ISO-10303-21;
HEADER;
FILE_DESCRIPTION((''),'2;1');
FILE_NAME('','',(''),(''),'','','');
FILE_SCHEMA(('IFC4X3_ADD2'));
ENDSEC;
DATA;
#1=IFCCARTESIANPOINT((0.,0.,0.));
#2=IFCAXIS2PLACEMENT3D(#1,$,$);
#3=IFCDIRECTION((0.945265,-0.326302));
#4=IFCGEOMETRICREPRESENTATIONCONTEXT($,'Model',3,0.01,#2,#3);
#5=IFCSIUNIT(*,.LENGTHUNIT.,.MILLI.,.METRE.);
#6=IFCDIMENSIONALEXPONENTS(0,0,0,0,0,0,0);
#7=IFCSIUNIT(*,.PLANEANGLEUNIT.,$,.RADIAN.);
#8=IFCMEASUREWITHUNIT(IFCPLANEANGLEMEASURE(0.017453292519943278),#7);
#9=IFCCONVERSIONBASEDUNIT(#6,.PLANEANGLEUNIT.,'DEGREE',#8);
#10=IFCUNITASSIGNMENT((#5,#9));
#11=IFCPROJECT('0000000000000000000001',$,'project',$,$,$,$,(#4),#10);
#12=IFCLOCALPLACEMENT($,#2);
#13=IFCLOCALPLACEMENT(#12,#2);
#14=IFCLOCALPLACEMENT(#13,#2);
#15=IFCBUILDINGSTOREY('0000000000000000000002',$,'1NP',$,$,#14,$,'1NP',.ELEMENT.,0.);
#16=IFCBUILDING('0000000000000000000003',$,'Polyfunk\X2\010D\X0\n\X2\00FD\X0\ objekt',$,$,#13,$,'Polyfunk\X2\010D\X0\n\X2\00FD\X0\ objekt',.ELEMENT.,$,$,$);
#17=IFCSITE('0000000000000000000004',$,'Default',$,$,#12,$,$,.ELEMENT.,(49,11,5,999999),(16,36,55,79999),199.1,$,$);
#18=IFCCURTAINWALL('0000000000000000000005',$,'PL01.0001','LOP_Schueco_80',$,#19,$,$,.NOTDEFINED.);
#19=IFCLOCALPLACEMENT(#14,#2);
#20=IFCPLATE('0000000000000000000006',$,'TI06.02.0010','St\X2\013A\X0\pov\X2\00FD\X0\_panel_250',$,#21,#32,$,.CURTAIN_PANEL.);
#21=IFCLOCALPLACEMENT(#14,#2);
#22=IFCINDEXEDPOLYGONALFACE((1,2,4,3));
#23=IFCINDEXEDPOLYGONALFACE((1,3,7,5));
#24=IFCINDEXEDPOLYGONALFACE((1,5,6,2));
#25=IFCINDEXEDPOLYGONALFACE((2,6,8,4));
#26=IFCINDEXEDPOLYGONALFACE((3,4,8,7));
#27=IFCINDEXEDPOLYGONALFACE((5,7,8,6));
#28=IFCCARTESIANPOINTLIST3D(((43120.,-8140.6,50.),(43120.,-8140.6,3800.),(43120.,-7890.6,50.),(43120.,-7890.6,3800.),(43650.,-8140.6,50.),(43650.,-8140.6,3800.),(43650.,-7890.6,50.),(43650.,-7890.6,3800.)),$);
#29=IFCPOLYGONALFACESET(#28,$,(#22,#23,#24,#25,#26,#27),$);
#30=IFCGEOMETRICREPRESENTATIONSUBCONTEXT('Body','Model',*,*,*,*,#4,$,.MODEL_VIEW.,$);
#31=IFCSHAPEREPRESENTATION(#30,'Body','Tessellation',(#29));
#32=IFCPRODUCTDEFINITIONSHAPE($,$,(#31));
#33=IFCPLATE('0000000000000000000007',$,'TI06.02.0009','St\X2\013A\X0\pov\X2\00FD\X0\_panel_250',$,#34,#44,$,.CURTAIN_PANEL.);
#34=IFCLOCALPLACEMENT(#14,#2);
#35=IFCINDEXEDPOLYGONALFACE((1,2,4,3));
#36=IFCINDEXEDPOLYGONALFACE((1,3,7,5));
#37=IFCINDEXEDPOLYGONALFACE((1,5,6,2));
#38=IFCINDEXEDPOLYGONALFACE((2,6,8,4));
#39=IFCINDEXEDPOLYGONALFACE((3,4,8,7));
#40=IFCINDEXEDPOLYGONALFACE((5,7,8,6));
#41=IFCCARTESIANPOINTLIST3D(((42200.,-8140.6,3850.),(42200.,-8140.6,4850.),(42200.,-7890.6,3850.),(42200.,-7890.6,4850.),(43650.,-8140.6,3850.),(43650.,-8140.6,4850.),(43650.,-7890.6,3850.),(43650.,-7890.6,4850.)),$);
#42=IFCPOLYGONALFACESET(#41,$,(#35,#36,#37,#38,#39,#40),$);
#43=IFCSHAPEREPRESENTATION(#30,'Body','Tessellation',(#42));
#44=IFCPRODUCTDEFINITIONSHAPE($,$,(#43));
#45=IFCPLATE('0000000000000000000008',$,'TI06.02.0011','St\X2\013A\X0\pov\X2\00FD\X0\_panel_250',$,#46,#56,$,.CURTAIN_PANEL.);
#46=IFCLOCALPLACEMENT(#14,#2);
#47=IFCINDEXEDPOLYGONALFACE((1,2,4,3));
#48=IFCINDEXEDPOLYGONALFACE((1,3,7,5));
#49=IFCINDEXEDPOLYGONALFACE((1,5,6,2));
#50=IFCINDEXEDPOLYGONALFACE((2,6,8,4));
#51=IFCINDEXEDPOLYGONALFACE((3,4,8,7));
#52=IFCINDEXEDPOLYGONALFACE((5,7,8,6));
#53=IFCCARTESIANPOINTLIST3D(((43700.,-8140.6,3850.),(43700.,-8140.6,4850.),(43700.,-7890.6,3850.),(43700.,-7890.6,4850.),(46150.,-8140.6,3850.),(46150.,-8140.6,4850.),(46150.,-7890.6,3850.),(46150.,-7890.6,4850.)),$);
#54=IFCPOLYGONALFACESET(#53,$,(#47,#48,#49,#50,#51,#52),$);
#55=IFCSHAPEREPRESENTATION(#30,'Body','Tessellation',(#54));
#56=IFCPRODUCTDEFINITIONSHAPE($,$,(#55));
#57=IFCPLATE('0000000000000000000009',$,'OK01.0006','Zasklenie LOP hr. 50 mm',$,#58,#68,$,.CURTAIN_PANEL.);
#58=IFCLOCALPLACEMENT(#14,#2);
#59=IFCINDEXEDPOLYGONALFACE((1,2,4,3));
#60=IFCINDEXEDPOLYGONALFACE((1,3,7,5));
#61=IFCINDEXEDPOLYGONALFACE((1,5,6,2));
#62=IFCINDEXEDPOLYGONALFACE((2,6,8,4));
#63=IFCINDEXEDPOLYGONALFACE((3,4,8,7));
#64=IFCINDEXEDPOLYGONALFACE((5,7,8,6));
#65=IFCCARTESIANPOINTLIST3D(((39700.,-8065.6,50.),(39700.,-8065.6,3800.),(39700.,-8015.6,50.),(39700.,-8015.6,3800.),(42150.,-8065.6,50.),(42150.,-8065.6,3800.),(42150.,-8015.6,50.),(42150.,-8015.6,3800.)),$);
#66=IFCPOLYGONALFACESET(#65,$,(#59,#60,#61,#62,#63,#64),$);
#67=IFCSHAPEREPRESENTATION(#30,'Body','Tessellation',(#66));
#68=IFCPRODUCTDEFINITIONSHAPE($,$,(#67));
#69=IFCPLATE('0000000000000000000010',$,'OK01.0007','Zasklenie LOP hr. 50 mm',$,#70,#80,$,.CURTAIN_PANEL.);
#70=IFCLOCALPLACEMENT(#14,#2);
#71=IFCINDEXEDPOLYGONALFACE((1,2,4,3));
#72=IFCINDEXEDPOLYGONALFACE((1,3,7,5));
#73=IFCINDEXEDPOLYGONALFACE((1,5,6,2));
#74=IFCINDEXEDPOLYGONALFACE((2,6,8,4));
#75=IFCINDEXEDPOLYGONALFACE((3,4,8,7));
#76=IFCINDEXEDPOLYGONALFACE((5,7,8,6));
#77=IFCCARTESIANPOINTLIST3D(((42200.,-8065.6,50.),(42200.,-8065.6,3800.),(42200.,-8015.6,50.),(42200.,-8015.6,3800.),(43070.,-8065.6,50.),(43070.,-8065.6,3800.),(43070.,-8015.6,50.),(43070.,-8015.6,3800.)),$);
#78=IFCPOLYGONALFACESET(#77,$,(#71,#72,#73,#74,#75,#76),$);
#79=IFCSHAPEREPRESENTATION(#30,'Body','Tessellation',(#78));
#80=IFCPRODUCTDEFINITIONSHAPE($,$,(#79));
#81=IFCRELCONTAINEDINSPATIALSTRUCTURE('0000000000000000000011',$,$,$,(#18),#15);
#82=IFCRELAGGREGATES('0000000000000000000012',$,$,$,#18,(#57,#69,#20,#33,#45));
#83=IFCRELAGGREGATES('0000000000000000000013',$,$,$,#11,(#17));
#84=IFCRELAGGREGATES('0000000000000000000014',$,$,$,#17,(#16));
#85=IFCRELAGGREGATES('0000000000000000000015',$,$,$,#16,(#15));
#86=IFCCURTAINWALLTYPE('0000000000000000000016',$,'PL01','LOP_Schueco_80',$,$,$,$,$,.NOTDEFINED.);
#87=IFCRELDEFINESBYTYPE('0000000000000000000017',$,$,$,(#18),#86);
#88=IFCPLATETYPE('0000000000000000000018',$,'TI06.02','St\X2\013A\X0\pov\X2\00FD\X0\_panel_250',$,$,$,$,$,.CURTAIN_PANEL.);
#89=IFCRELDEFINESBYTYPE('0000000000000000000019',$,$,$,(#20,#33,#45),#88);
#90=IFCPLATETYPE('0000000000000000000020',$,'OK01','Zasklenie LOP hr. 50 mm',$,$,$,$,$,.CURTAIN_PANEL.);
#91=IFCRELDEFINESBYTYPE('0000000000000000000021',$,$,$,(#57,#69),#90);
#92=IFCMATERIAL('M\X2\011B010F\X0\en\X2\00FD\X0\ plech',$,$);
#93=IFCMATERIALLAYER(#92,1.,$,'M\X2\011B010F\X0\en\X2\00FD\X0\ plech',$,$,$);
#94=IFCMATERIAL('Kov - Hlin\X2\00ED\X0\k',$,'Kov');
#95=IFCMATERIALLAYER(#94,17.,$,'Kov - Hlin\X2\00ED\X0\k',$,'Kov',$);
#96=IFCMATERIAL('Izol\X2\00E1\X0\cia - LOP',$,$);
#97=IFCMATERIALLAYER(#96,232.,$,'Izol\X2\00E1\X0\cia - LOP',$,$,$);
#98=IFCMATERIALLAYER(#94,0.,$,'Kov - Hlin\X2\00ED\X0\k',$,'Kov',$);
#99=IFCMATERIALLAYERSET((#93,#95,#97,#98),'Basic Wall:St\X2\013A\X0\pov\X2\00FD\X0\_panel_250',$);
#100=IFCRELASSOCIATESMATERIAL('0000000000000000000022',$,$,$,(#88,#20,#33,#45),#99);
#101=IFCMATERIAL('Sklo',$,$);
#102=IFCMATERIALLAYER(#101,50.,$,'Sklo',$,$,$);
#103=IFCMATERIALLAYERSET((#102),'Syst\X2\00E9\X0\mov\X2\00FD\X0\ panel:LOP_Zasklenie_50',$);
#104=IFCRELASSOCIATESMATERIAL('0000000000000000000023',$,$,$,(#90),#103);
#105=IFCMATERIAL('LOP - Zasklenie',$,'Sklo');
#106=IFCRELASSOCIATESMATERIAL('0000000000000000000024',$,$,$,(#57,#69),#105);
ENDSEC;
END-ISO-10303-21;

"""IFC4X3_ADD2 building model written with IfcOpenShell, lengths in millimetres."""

from ifc_helpers import new_model, entity, si_unit, converted_unit, direction, frame, frame_2d, origin, place, context, subcontext, project, spatial, rectangle, extrude, source, transform, mapped, material, layer, layer_set, layer_usage, type_object, type_shapes, element, aggregate, save


model = new_model("IFC4X3_ADD2")

# Units and contexts
model_context = context("Model", 3, precision=0.01, world=origin(), true_north=direction((0.945265, -0.326302)))
body_context = subcontext(model_context, "Body", "Model", "MODEL_VIEW")
ifc_project = project(units=[si_unit("LENGTHUNIT", "METRE", prefix="MILLI"), converted_unit("PLANEANGLEUNIT", "DEGREE", entity("IfcPlaneAngleMeasure", 0.017453292519943278), si_unit("PLANEANGLEUNIT", "RADIAN"), dimensions=[0, 0, 0, 0, 0, 0, 0])], contexts=[model_context])

# Site, building, storey
site_placement = place(None, origin())
site = spatial("IfcSite", under=ifc_project, at=site_placement, Name="Default", CompositionType="ELEMENT", RefLatitude=(49, 11, 5, 999999), RefLongitude=(16, 36, 55, 79999), RefElevation=199.1)
building_placement = place(site_placement, origin())
building = spatial("IfcBuilding", under=site, at=building_placement, Name="Polyfunkčný objekt", LongName="Polyfunkčný objekt", CompositionType="ELEMENT")
storey_placement = place(building_placement, origin())
storey = spatial("IfcBuildingStorey", under=building, at=storey_placement, Name="1NP", LongName="1NP", CompositionType="ELEMENT", Elevation=0.0)

# Curtain wall, plates
curtain_wall_type = type_object("IfcCurtainWallType", Name="PL01", Description="LOP_Schueco_80", PredefinedType="NOTDEFINED")
curtain_wall_placement = place(storey_placement, origin())
curtain_wall = element("IfcCurtainWall", 1, at=curtain_wall_placement, inside=storey, type_object=curtain_wall_type, Name="PL01.0001", Description="LOP_Schueco_80", PredefinedType="NOTDEFINED")
ifc_material_1 = material(Name="Měďený plech")
ifc_layer_1 = layer(ifc_material_1, 1.0, Name="Měďený plech")
ifc_material_2 = material(Name="Kov - Hliník", Category="Kov")
ifc_layer_2 = layer(ifc_material_2, 17.0, Name="Kov - Hliník", Category="Kov")
ifc_material_3 = material(Name="Izolácia - LOP")
ifc_layer_3 = layer(ifc_material_3, 232.0, Name="Izolácia - LOP")
ifc_layer_4 = layer(ifc_material_2, 0.0, Name="Kov - Hliník", Category="Kov")
ifc_layer_set_1 = layer_set([ifc_layer_1, ifc_layer_2, ifc_layer_3, ifc_layer_4], Name="Basic Wall:Stĺpový_panel_250")
ifc_layer_usage_1 = layer_usage(ifc_layer_set_1, "AXIS2", "POSITIVE", -125.0)
plate_type_1 = type_object("IfcPlateType", Name="TI06.02", Description="Stĺpový_panel_250", PredefinedType="CURTAIN_PANEL", material=ifc_layer_set_1)
plate_1_placement = place(storey_placement, frame((43120.0, -8015.6, 50.0)))
plate_1 = element("IfcPlate", 2, at=plate_1_placement, type_object=plate_type_1, material=ifc_layer_usage_1, Name="TI06.02.0010", Description="Stĺpový_panel_250", PredefinedType="CURTAIN_PANEL", context=body_context, shape_type="SweptSolid", body=[
    extrude(rectangle(XDim=250.0, YDim=530.0, at=frame_2d((0.0, 0.0), x_axis=(1.0, 0.0))), frame((265.0, 0.0, 0.0), z_axis=(0.0, 0.0, 1.0), x_axis=(0.0, 1.0, 0.0)), (0.0, 0.0, 1.0), 3750.0),
])
ifc_layer_usage_2 = layer_usage(ifc_layer_set_1, "AXIS2", "POSITIVE", -125.0)
plate_2_placement = place(storey_placement, frame((42200.0, -8015.6, 3850.0)))
plate_2 = element("IfcPlate", 3, at=plate_2_placement, type_object=plate_type_1, material=ifc_layer_usage_2, Name="TI06.02.0009", Description="Stĺpový_panel_250", PredefinedType="CURTAIN_PANEL", context=body_context, shape_type="SweptSolid", body=[
    extrude(rectangle(XDim=250.0, YDim=1450.0, at=frame_2d((0.0, 0.0), x_axis=(1.0, 0.0))), frame((725.0, 0.0, 0.0), z_axis=(0.0, 0.0, 1.0), x_axis=(0.0, 1.0, 0.0)), (0.0, 0.0, 1.0), 1000.0),
])
ifc_layer_usage_3 = layer_usage(ifc_layer_set_1, "AXIS2", "POSITIVE", -125.0)
plate_3_placement = place(storey_placement, frame((43700.0, -8015.6, 3850.0)))
plate_3 = element("IfcPlate", 4, at=plate_3_placement, type_object=plate_type_1, material=ifc_layer_usage_3, Name="TI06.02.0011", Description="Stĺpový_panel_250", PredefinedType="CURTAIN_PANEL", context=body_context, shape_type="SweptSolid", body=[
    extrude(rectangle(XDim=250.0, YDim=2450.0, at=frame_2d((0.0, 0.0), x_axis=(1.0, 0.0))), frame((1225.0, 0.0, 0.0), z_axis=(0.0, 0.0, 1.0), x_axis=(0.0, 1.0, 0.0)), (0.0, 0.0, 1.0), 1000.0),
])
ifc_material_4 = material(Name="LOP - Zasklenie", Category="Sklo")
ifc_material_5 = material(Name="Sklo")
ifc_layer_5 = layer(ifc_material_5, 50.0, Name="Sklo")
ifc_layer_set_2 = layer_set([ifc_layer_5], Name="Systémový panel:LOP_Zasklenie_50")
plate_type_2 = type_object("IfcPlateType", Name="OK01", Description="Zasklenie LOP hr. 50 mm", PredefinedType="CURTAIN_PANEL", material=ifc_layer_set_2)
shared_shape_1 = source(origin(), body_context, "Body", "SweptSolid", [
    extrude(rectangle(XDim=3750.0, YDim=2450.0, at=frame_2d((-331.2, 0.0), x_axis=(1.0, 0.0))), frame((0.0, -50.0, 2206.2), z_axis=(0.0, 1.0, 0.0), x_axis=(0.0, 0.0, 1.0)), (0.0, 0.0, 1.0), 50.0),
])
plate_4_placement = place(curtain_wall_placement, frame((40925.0, -8015.6, 50.0)))
plate_4 = element("IfcPlate", 5, at=plate_4_placement, type_object=plate_type_2, material=ifc_material_4, Name="OK01.0006", Description="Zasklenie LOP hr. 50 mm", PredefinedType="CURTAIN_PANEL", context=body_context, shape_type="MappedRepresentation", body=[
    mapped(shared_shape_1, transform((0.0, 0.0, 0.0), scale=1.0)),
])
shared_shape_2 = source(origin(), body_context, "Body", "SweptSolid", [
    extrude(rectangle(XDim=3750.0, YDim=870.0, at=frame_2d((-331.2, 0.0), x_axis=(1.0, 0.0))), frame((0.0, -50.0, 2206.2), z_axis=(0.0, 1.0, 0.0), x_axis=(0.0, 0.0, 1.0)), (0.0, 0.0, 1.0), 50.0),
])
type_shapes(plate_type_2, [shared_shape_1, shared_shape_2])
plate_5_placement = place(curtain_wall_placement, frame((42635.0, -8015.6, 50.0)))
plate_5 = element("IfcPlate", 6, at=plate_5_placement, type_object=plate_type_2, material=ifc_material_4, Name="OK01.0007", Description="Zasklenie LOP hr. 50 mm", PredefinedType="CURTAIN_PANEL", context=body_context, shape_type="MappedRepresentation", body=[
    mapped(shared_shape_2, transform((0.0, 0.0, 0.0), scale=1.0)),
])
aggregate(curtain_wall, [plate_4, plate_5, plate_1, plate_2, plate_3])

save(model, "model.ifc")
